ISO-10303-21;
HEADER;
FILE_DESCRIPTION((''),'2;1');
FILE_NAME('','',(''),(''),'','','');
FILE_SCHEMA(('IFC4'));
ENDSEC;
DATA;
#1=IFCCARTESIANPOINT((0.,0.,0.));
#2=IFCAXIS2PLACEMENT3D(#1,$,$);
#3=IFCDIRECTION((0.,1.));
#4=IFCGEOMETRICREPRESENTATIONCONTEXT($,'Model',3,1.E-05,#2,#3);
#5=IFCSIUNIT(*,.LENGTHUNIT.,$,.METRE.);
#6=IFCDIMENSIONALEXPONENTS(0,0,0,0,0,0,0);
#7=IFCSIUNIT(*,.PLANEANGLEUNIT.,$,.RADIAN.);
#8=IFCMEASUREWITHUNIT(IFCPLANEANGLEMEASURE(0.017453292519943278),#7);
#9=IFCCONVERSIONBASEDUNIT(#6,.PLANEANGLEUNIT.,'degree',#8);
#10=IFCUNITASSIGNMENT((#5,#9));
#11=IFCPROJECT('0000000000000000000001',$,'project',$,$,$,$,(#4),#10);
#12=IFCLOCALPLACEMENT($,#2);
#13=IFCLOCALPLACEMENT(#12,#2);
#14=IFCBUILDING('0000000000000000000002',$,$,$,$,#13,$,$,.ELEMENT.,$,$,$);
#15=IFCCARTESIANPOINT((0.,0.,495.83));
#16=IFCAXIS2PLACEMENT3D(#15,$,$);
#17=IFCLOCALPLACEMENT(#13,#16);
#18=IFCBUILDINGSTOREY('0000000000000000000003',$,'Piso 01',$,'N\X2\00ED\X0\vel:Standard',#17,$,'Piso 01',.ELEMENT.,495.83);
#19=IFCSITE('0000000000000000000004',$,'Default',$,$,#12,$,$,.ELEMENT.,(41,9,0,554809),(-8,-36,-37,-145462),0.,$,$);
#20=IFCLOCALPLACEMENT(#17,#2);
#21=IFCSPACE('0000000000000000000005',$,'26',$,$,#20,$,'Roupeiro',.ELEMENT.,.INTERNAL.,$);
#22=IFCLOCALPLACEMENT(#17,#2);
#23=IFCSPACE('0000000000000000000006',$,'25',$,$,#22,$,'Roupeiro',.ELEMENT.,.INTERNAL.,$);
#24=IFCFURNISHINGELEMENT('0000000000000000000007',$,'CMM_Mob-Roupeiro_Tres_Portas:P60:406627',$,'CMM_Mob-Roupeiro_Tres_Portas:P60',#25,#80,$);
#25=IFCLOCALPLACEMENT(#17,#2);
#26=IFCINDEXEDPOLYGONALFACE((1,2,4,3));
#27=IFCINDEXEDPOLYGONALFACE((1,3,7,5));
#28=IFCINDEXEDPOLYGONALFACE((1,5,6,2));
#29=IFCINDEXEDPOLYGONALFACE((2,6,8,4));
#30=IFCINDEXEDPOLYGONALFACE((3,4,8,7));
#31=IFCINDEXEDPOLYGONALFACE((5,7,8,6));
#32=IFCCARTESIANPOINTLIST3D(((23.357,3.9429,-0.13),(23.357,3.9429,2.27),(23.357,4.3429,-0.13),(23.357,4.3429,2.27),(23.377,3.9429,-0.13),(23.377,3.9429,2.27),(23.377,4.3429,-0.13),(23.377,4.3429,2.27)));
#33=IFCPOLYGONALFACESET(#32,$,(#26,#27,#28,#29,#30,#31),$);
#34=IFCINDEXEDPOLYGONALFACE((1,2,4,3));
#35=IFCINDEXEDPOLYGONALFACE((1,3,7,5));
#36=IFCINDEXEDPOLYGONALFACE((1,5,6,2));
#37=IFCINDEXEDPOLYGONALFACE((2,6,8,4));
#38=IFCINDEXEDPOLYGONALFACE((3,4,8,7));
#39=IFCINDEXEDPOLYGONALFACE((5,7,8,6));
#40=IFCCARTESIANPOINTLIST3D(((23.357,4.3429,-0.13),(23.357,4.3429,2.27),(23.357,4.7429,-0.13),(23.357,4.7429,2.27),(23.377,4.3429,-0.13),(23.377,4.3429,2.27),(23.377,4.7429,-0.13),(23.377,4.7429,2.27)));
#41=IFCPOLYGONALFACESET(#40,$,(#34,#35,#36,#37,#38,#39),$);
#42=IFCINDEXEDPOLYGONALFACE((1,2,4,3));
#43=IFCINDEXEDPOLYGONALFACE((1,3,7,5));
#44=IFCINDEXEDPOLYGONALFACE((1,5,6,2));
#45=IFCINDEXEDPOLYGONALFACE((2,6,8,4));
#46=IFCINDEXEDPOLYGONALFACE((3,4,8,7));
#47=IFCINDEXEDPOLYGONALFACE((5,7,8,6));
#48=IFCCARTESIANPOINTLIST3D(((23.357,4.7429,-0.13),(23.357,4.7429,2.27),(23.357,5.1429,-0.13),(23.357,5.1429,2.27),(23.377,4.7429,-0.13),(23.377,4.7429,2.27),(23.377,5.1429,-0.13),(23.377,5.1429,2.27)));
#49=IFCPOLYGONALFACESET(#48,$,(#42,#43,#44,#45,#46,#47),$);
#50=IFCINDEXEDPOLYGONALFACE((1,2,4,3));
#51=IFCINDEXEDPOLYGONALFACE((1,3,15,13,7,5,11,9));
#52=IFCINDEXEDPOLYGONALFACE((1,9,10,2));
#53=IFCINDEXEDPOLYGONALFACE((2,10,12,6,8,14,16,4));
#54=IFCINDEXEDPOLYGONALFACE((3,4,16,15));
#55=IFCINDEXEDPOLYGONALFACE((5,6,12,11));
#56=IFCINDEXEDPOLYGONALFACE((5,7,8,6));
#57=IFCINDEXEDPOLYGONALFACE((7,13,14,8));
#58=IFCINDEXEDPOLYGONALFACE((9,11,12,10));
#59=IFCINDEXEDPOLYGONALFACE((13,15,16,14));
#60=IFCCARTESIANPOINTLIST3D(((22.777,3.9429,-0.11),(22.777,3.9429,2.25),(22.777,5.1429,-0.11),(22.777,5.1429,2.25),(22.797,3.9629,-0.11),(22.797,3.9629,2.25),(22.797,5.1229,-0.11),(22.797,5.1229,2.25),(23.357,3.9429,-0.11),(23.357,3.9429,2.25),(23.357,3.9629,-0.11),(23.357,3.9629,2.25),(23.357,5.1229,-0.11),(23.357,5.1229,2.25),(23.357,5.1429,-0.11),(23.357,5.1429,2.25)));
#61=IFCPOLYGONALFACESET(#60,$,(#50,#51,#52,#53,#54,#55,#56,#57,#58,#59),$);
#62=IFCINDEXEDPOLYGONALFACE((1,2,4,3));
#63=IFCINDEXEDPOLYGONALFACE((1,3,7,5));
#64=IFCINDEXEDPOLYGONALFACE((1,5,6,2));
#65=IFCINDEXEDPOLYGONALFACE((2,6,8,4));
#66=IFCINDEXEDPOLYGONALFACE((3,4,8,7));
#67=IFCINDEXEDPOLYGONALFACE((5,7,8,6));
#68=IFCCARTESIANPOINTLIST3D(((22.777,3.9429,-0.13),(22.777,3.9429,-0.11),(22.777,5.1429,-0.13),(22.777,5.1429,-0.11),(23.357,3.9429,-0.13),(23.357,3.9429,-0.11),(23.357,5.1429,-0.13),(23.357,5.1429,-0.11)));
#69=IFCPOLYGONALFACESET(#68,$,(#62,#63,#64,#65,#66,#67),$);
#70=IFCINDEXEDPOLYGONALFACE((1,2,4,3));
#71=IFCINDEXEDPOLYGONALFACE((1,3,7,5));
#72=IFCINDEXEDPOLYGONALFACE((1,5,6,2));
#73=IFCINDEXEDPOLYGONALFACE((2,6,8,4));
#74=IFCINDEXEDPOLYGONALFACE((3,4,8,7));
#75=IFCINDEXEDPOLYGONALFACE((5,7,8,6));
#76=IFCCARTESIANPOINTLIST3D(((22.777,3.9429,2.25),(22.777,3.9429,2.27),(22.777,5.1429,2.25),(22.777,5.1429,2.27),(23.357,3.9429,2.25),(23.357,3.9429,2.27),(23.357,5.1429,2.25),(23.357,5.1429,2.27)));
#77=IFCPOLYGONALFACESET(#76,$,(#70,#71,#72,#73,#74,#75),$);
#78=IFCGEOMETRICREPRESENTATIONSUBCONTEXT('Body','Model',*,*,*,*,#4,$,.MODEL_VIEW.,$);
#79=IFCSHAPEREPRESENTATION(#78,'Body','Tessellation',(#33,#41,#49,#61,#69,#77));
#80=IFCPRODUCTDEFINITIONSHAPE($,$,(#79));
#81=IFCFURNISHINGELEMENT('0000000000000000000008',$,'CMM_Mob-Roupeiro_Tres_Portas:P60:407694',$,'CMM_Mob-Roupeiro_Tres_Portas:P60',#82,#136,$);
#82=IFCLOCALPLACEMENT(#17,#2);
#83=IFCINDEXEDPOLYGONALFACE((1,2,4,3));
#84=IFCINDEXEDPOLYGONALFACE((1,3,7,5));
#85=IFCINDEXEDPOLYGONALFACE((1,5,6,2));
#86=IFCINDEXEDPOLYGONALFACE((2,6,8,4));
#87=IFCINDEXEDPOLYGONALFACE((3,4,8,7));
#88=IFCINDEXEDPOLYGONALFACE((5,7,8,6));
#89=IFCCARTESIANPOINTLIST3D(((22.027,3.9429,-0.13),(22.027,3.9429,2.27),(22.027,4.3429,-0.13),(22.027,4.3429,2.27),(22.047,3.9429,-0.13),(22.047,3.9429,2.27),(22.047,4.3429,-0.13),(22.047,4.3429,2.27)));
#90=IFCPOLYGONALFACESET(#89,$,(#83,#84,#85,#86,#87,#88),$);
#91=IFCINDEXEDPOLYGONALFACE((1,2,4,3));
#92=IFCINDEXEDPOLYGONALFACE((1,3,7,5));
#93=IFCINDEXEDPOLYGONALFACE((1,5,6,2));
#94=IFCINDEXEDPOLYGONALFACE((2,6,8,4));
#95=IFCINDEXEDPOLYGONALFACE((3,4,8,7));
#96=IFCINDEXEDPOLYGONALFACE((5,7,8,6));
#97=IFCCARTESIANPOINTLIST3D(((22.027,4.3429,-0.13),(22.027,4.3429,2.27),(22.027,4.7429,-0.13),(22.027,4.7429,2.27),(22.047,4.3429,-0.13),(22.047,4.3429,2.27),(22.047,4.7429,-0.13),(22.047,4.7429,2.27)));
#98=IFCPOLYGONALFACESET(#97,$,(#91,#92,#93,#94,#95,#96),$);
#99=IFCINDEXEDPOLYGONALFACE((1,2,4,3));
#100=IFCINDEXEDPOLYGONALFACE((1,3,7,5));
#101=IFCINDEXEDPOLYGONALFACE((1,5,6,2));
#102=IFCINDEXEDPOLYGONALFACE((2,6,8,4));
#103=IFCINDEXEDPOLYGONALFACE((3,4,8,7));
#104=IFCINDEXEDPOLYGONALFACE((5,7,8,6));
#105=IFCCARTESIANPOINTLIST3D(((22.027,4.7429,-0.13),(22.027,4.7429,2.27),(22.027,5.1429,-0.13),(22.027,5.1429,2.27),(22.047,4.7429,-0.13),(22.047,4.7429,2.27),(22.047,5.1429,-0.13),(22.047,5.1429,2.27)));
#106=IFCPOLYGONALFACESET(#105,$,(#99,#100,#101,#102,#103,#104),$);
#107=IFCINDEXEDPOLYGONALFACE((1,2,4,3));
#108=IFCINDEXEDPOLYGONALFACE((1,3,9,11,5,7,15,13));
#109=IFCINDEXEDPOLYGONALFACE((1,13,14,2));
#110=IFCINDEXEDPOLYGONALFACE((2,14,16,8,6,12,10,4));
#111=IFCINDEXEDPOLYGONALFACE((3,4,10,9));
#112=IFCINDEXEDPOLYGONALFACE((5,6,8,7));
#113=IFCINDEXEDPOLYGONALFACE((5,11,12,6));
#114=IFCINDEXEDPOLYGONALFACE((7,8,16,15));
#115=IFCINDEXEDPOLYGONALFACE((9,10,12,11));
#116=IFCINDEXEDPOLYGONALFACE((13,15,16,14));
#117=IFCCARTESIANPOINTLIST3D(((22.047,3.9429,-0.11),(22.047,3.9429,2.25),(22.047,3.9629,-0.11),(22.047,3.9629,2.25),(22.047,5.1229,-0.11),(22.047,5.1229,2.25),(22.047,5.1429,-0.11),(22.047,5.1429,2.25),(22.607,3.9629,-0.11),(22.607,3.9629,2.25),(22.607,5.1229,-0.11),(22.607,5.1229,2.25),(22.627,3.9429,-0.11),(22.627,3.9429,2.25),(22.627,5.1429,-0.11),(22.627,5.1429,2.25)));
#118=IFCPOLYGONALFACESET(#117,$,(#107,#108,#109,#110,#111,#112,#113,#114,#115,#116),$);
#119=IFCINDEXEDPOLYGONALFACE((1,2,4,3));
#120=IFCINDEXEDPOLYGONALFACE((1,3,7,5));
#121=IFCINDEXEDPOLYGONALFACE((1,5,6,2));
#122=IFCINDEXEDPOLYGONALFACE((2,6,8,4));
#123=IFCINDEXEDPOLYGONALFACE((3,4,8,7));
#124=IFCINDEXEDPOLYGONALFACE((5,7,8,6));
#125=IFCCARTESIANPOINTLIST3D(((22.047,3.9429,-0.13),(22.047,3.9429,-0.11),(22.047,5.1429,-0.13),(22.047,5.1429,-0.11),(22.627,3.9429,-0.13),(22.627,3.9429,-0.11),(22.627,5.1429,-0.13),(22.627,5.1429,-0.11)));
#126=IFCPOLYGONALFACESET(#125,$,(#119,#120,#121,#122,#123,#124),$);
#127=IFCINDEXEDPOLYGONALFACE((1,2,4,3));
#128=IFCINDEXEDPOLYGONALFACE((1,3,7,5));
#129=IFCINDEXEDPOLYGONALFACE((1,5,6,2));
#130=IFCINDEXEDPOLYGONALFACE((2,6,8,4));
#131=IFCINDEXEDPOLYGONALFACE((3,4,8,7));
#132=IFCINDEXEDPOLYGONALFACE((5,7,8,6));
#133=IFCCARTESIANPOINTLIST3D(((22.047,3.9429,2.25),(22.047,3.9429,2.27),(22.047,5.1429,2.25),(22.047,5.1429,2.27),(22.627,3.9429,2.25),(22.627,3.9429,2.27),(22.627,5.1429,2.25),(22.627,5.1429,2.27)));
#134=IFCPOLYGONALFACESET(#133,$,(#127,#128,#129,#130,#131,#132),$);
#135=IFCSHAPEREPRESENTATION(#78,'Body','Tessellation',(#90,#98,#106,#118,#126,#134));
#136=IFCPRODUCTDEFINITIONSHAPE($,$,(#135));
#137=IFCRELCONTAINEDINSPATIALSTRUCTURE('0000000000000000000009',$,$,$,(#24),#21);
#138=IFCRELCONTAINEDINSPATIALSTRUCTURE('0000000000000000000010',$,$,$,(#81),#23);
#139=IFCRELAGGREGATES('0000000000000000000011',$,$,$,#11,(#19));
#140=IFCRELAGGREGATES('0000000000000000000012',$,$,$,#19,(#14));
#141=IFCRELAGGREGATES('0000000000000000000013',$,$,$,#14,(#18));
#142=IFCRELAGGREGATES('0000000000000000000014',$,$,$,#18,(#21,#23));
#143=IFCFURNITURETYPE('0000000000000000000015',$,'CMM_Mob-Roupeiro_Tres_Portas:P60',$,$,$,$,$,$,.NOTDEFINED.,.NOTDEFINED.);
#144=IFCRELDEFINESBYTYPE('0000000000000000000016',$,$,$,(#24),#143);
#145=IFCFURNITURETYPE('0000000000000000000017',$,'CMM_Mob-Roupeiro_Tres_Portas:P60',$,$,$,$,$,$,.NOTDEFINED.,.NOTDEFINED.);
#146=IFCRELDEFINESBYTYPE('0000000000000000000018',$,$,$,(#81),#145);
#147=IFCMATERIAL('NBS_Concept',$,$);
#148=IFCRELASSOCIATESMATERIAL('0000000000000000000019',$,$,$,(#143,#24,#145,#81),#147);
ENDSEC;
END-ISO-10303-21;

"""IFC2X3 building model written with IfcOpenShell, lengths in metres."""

from ifc_helpers import new_model, entity, si_unit, converted_unit, direction, frame, frame_2d, origin, place, context, subcontext, project, spatial, polyline, rectangle, outline, extrude, source, transform, mapped, material, type_object, type_shapes, element, save


model = new_model("IFC2X3")

# Units and contexts
model_context = context("Model", 3, precision=1e-05, world=origin(), true_north=direction((0.0, 1.0)))
body_context = subcontext(model_context, "Body", "Model", "MODEL_VIEW")
ifc_project = project(units=[si_unit("LENGTHUNIT", "METRE"), converted_unit("PLANEANGLEUNIT", "degree", entity("IfcPlaneAngleMeasure", 0.017453292519943278), si_unit("PLANEANGLEUNIT", "RADIAN"), dimensions=[0, 0, 0, 0, 0, 0, 0])], contexts=[model_context])

# Site, building, storey
site_placement = place(None, origin())
site = spatial("IfcSite", under=ifc_project, at=site_placement, Name="Default", CompositionType="ELEMENT", RefLatitude=(41, 9, 0, 554809), RefLongitude=(-8, -36, -37, -145462), RefElevation=0.0)
building_placement = place(site_placement, origin())
building = spatial("IfcBuilding", under=site, at=building_placement, CompositionType="ELEMENT")
storey_placement = place(building_placement, frame((0.0, 0.0, 495.83)))
storey = spatial("IfcBuildingStorey", under=building, at=storey_placement, Name="Piso 01", ObjectType="Nível:Standard", LongName="Piso 01", CompositionType="ELEMENT", Elevation=495.83)

# Shared definitions
ifc_material_1 = material(Name="NBS_Concept")

# Shared definitions
space_1_placement = place(storey_placement, origin())
space_1 = spatial("IfcSpace", under=storey, at=space_1_placement, Name="26", LongName="Roupeiro", CompositionType="ELEMENT", InteriorOrExteriorSpace="INTERNAL")

# Furnishing element
furniture_type_1 = type_object("IfcFurnitureType", Name="CMM_Mob-Roupeiro_Tres_Portas:P60", AssemblyPlace="NOTDEFINED", material=ifc_material_1)
shared_shape_1 = source(origin(), body_context, "Body", "SweptSolid", [
    extrude(rectangle(XDim=0.4, YDim=0.02, at=frame_2d((0.0, 0.0), x_axis=(1.0, 0.0))), frame((1.0, 0.59, 0.0), z_axis=(0.0, 0.0, 1.0), x_axis=(-1.0, 0.0, 0.0)), (0.0, 0.0, 1.0), 2.4),
    extrude(rectangle(XDim=0.4, YDim=0.02, at=frame_2d((0.0, 0.0), x_axis=(1.0, 0.0))), frame((0.6, 0.59, 0.0), z_axis=(0.0, 0.0, 1.0), x_axis=(-1.0, 0.0, 0.0)), (0.0, 0.0, 1.0), 2.4),
    extrude(rectangle(XDim=0.4, YDim=0.02, at=frame_2d((0.0, 0.0), x_axis=(1.0, 0.0))), frame((0.2, 0.59, 0.0), z_axis=(0.0, 0.0, 1.0), x_axis=(-1.0, 0.0, 0.0)), (0.0, 0.0, 1.0), 2.4),
    extrude(outline(polyline([(-0.6, -0.295), (0.6, -0.295), (0.6, 0.285), (0.58, 0.285), (0.58, -0.275), (-0.58, -0.275), (-0.58, 0.285), (-0.6, 0.285), (-0.6, -0.295)])), frame((0.6, 0.295, 0.02)), (0.0, 0.0, 1.0), 2.36),
    extrude(rectangle(XDim=1.2, YDim=0.58, at=frame_2d((0.0, 0.0), x_axis=(1.0, 0.0))), frame((0.6, 0.29, 0.0), z_axis=(0.0, 0.0, 1.0), x_axis=(-1.0, 0.0, 0.0)), (0.0, 0.0, 1.0), 0.02),
    extrude(rectangle(XDim=1.2, YDim=0.58, at=frame_2d((0.0, 0.0), x_axis=(1.0, 0.0))), frame((0.6, 0.29, 2.38), z_axis=(0.0, 0.0, 1.0), x_axis=(-1.0, 0.0, 0.0)), (0.0, 0.0, 1.0), 0.02),
])
type_shapes(furniture_type_1, [shared_shape_1])
furnishing_1_placement = place(space_1_placement, frame((22.777, 5.1429, -0.13), z_axis=(0.0, 0.0, 1.0), x_axis=(0.0, -1.0, 0.0)))
element("IfcFurnishingElement", 1, at=furnishing_1_placement, inside=space_1, type_object=furniture_type_1, material=ifc_material_1, Name="CMM_Mob-Roupeiro_Tres_Portas:P60:406627", ObjectType="CMM_Mob-Roupeiro_Tres_Portas:P60", context=body_context, shape_type="MappedRepresentation", body=[
    mapped(shared_shape_1, transform((0.0, 0.0, 0.0), scale=1.0)),
])

# Shared definitions
space_2_placement = place(storey_placement, origin())
space_2 = spatial("IfcSpace", under=storey, at=space_2_placement, Name="25", LongName="Roupeiro", CompositionType="ELEMENT", InteriorOrExteriorSpace="INTERNAL")

# Furnishing element
furniture_type_2 = type_object("IfcFurnitureType", Name="CMM_Mob-Roupeiro_Tres_Portas:P60", AssemblyPlace="NOTDEFINED", material=ifc_material_1)
shared_shape_2 = source(origin(), body_context, "Body", "SweptSolid", [
    extrude(rectangle(XDim=0.02, YDim=0.4, at=frame_2d((0.0, 0.0), x_axis=(1.0, 0.0))), frame((1.0, -0.59, 0.0), z_axis=(0.0, 0.0, 1.0), x_axis=(0.0, 1.0, 0.0)), (0.0, 0.0, 1.0), 2.4),
    extrude(rectangle(XDim=0.02, YDim=0.4, at=frame_2d((0.0, 0.0), x_axis=(1.0, 0.0))), frame((0.6, -0.59, 0.0), z_axis=(0.0, 0.0, 1.0), x_axis=(0.0, 1.0, 0.0)), (0.0, 0.0, 1.0), 2.4),
    extrude(rectangle(XDim=0.02, YDim=0.4, at=frame_2d((0.0, 0.0), x_axis=(1.0, 0.0))), frame((0.2, -0.59, 0.0), z_axis=(0.0, 0.0, 1.0), x_axis=(0.0, 1.0, 0.0)), (0.0, 0.0, 1.0), 2.4),
    extrude(outline(polyline([(-0.295, -0.6), (0.285, -0.6), (0.285, -0.58), (-0.275, -0.58), (-0.275, 0.58), (0.285, 0.58), (0.285, 0.6), (-0.295, 0.6), (-0.295, -0.6)])), frame((0.6, -0.295, 0.02), z_axis=(0.0, 0.0, 1.0), x_axis=(0.0, -1.0, 0.0)), (0.0, 0.0, 1.0), 2.36),
    extrude(rectangle(XDim=0.58, YDim=1.2, at=frame_2d((0.0, 0.0), x_axis=(1.0, 0.0))), frame((0.6, -0.29, 0.0), z_axis=(0.0, 0.0, 1.0), x_axis=(0.0, 1.0, 0.0)), (0.0, 0.0, 1.0), 0.02),
    extrude(rectangle(XDim=0.58, YDim=1.2, at=frame_2d((0.0, 0.0), x_axis=(1.0, 0.0))), frame((0.6, -0.29, 2.38), z_axis=(0.0, 0.0, 1.0), x_axis=(0.0, 1.0, 0.0)), (0.0, 0.0, 1.0), 0.02),
])
type_shapes(furniture_type_2, [shared_shape_2])
furnishing_2_placement = place(space_2_placement, frame((22.627, 5.1429, -0.13), z_axis=(0.0, 0.0, 1.0), x_axis=(0.0, -1.0, 0.0)))
element("IfcFurnishingElement", 2, at=furnishing_2_placement, inside=space_2, type_object=furniture_type_2, material=ifc_material_1, Name="CMM_Mob-Roupeiro_Tres_Portas:P60:407694", ObjectType="CMM_Mob-Roupeiro_Tres_Portas:P60", context=body_context, shape_type="MappedRepresentation", body=[
    mapped(shared_shape_2, transform((0.0, 0.0, 0.0), scale=1.0)),
])

save(model, "model.ifc")
